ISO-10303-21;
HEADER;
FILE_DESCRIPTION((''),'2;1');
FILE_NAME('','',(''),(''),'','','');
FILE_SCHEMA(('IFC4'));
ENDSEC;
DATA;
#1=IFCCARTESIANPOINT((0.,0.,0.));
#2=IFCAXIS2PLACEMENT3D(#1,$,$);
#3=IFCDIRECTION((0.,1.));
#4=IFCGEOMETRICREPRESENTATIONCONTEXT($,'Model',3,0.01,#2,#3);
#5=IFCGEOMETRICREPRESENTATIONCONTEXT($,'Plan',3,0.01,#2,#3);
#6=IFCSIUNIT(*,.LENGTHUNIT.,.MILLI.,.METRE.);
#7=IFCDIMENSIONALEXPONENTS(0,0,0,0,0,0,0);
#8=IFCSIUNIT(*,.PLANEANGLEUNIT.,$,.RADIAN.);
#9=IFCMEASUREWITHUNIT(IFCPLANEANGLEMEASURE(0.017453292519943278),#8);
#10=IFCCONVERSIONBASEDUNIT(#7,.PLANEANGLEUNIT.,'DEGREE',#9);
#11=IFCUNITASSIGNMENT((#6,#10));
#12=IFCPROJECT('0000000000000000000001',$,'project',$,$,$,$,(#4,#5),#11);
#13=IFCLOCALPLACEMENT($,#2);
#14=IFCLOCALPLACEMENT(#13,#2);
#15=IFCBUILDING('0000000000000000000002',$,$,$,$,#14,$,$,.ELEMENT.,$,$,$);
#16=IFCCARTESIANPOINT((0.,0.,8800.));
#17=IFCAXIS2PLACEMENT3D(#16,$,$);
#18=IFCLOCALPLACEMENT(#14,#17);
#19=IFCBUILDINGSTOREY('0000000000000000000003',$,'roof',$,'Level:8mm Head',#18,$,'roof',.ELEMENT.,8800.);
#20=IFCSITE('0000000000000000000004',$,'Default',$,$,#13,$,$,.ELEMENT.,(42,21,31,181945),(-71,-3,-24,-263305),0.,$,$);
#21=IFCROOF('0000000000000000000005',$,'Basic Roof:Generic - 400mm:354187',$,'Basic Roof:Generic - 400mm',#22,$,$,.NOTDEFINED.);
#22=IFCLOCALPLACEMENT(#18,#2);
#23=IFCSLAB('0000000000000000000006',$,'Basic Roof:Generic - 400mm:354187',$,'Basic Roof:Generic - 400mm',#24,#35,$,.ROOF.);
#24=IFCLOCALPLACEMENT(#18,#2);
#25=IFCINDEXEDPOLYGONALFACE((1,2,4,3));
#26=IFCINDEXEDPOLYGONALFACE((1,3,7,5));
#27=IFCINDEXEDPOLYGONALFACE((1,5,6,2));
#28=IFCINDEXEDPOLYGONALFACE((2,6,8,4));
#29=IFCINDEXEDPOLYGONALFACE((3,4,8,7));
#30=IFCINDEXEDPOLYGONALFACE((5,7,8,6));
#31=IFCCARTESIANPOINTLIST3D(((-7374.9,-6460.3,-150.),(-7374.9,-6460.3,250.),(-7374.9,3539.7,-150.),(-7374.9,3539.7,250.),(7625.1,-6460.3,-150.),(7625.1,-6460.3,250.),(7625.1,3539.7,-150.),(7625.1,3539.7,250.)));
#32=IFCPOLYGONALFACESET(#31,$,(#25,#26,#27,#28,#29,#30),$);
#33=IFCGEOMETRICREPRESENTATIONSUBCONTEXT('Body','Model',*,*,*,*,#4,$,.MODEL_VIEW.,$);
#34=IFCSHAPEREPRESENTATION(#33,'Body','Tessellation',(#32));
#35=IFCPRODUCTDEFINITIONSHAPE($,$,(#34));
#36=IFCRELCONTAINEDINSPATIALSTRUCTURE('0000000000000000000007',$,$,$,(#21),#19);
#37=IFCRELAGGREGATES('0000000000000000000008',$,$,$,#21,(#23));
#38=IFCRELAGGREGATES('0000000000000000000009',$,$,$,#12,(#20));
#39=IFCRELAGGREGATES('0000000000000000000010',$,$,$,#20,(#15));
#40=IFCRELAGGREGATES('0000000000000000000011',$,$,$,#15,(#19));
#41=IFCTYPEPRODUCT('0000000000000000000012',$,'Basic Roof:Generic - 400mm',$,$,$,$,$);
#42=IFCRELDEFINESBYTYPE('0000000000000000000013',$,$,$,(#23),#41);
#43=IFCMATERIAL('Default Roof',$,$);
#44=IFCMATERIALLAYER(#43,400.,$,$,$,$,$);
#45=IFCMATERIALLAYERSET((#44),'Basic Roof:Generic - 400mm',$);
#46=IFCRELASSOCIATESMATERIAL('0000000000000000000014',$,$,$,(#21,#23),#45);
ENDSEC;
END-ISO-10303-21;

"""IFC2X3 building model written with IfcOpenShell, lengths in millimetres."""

from ifc_helpers import new_model, entity, si_unit, converted_unit, direction, frame, origin, origin_2d_with_axis, place, context, subcontext, project, spatial, rectangle, extrude, material, layer, layer_set, type_object, element, aggregate, save


model = new_model("IFC2X3")

# Units and contexts
model_context = context("Model", 3, precision=0.01, world=origin(), true_north=direction((0.0, 1.0)))
plan_context = context("Plan", 3, precision=0.01, world=origin(), true_north=direction((0.0, 1.0)))
body_context = subcontext(model_context, "Body", "Model", "MODEL_VIEW")
ifc_project = project(units=[si_unit("LENGTHUNIT", "METRE", prefix="MILLI"), converted_unit("PLANEANGLEUNIT", "DEGREE", entity("IfcPlaneAngleMeasure", 0.017453292519943278), si_unit("PLANEANGLEUNIT", "RADIAN"), dimensions=[0, 0, 0, 0, 0, 0, 0])], contexts=[model_context, plan_context])

# Site, building, storey
site_placement = place(None, origin())
site = spatial("IfcSite", under=ifc_project, at=site_placement, Name="Default", CompositionType="ELEMENT", RefLatitude=(42, 21, 31, 181945), RefLongitude=(-71, -3, -24, -263305), RefElevation=0.0)
building_placement = place(site_placement, origin())
building = spatial("IfcBuilding", under=site, at=building_placement, CompositionType="ELEMENT")
storey_placement = place(building_placement, frame((0.0, 0.0, 8800.0)))
storey = spatial("IfcBuildingStorey", under=building, at=storey_placement, Name="roof", ObjectType="Level:8mm Head", LongName="roof", CompositionType="ELEMENT", Elevation=8800.0)

# Roof, slab
ifc_material = material(Name="Default Roof")
ifc_layer = layer(ifc_material, 400.0)
ifc_layer_set = layer_set([ifc_layer], Name="Basic Roof:Generic - 400mm")
roof_placement = place(storey_placement, frame((-7374.9, -6460.3, -150.0)))
roof = element("IfcRoof", 1, at=roof_placement, inside=storey, material=ifc_layer_set, Name="Basic Roof:Generic - 400mm:354187", ObjectType="Basic Roof:Generic - 400mm", ShapeType="NOTDEFINED")
type_product = type_object("IfcTypeProduct", Name="Basic Roof:Generic - 400mm")
slab_placement = place(roof_placement, origin())
slab = element("IfcSlab", 2, at=slab_placement, type_object=type_product, material=ifc_layer_set, Name="Basic Roof:Generic - 400mm:354187", ObjectType="Basic Roof:Generic - 400mm", PredefinedType="ROOF", context=body_context, shape_type="SweptSolid", body=[
    extrude(rectangle(XDim=15000.0, YDim=10000.0, at=origin_2d_with_axis()), frame((7500.0, 5000.0, 0.0)), (0.0, 0.0, 1.0), 400.0),
])
aggregate(roof, [slab])

save(model, "model.ifc")
